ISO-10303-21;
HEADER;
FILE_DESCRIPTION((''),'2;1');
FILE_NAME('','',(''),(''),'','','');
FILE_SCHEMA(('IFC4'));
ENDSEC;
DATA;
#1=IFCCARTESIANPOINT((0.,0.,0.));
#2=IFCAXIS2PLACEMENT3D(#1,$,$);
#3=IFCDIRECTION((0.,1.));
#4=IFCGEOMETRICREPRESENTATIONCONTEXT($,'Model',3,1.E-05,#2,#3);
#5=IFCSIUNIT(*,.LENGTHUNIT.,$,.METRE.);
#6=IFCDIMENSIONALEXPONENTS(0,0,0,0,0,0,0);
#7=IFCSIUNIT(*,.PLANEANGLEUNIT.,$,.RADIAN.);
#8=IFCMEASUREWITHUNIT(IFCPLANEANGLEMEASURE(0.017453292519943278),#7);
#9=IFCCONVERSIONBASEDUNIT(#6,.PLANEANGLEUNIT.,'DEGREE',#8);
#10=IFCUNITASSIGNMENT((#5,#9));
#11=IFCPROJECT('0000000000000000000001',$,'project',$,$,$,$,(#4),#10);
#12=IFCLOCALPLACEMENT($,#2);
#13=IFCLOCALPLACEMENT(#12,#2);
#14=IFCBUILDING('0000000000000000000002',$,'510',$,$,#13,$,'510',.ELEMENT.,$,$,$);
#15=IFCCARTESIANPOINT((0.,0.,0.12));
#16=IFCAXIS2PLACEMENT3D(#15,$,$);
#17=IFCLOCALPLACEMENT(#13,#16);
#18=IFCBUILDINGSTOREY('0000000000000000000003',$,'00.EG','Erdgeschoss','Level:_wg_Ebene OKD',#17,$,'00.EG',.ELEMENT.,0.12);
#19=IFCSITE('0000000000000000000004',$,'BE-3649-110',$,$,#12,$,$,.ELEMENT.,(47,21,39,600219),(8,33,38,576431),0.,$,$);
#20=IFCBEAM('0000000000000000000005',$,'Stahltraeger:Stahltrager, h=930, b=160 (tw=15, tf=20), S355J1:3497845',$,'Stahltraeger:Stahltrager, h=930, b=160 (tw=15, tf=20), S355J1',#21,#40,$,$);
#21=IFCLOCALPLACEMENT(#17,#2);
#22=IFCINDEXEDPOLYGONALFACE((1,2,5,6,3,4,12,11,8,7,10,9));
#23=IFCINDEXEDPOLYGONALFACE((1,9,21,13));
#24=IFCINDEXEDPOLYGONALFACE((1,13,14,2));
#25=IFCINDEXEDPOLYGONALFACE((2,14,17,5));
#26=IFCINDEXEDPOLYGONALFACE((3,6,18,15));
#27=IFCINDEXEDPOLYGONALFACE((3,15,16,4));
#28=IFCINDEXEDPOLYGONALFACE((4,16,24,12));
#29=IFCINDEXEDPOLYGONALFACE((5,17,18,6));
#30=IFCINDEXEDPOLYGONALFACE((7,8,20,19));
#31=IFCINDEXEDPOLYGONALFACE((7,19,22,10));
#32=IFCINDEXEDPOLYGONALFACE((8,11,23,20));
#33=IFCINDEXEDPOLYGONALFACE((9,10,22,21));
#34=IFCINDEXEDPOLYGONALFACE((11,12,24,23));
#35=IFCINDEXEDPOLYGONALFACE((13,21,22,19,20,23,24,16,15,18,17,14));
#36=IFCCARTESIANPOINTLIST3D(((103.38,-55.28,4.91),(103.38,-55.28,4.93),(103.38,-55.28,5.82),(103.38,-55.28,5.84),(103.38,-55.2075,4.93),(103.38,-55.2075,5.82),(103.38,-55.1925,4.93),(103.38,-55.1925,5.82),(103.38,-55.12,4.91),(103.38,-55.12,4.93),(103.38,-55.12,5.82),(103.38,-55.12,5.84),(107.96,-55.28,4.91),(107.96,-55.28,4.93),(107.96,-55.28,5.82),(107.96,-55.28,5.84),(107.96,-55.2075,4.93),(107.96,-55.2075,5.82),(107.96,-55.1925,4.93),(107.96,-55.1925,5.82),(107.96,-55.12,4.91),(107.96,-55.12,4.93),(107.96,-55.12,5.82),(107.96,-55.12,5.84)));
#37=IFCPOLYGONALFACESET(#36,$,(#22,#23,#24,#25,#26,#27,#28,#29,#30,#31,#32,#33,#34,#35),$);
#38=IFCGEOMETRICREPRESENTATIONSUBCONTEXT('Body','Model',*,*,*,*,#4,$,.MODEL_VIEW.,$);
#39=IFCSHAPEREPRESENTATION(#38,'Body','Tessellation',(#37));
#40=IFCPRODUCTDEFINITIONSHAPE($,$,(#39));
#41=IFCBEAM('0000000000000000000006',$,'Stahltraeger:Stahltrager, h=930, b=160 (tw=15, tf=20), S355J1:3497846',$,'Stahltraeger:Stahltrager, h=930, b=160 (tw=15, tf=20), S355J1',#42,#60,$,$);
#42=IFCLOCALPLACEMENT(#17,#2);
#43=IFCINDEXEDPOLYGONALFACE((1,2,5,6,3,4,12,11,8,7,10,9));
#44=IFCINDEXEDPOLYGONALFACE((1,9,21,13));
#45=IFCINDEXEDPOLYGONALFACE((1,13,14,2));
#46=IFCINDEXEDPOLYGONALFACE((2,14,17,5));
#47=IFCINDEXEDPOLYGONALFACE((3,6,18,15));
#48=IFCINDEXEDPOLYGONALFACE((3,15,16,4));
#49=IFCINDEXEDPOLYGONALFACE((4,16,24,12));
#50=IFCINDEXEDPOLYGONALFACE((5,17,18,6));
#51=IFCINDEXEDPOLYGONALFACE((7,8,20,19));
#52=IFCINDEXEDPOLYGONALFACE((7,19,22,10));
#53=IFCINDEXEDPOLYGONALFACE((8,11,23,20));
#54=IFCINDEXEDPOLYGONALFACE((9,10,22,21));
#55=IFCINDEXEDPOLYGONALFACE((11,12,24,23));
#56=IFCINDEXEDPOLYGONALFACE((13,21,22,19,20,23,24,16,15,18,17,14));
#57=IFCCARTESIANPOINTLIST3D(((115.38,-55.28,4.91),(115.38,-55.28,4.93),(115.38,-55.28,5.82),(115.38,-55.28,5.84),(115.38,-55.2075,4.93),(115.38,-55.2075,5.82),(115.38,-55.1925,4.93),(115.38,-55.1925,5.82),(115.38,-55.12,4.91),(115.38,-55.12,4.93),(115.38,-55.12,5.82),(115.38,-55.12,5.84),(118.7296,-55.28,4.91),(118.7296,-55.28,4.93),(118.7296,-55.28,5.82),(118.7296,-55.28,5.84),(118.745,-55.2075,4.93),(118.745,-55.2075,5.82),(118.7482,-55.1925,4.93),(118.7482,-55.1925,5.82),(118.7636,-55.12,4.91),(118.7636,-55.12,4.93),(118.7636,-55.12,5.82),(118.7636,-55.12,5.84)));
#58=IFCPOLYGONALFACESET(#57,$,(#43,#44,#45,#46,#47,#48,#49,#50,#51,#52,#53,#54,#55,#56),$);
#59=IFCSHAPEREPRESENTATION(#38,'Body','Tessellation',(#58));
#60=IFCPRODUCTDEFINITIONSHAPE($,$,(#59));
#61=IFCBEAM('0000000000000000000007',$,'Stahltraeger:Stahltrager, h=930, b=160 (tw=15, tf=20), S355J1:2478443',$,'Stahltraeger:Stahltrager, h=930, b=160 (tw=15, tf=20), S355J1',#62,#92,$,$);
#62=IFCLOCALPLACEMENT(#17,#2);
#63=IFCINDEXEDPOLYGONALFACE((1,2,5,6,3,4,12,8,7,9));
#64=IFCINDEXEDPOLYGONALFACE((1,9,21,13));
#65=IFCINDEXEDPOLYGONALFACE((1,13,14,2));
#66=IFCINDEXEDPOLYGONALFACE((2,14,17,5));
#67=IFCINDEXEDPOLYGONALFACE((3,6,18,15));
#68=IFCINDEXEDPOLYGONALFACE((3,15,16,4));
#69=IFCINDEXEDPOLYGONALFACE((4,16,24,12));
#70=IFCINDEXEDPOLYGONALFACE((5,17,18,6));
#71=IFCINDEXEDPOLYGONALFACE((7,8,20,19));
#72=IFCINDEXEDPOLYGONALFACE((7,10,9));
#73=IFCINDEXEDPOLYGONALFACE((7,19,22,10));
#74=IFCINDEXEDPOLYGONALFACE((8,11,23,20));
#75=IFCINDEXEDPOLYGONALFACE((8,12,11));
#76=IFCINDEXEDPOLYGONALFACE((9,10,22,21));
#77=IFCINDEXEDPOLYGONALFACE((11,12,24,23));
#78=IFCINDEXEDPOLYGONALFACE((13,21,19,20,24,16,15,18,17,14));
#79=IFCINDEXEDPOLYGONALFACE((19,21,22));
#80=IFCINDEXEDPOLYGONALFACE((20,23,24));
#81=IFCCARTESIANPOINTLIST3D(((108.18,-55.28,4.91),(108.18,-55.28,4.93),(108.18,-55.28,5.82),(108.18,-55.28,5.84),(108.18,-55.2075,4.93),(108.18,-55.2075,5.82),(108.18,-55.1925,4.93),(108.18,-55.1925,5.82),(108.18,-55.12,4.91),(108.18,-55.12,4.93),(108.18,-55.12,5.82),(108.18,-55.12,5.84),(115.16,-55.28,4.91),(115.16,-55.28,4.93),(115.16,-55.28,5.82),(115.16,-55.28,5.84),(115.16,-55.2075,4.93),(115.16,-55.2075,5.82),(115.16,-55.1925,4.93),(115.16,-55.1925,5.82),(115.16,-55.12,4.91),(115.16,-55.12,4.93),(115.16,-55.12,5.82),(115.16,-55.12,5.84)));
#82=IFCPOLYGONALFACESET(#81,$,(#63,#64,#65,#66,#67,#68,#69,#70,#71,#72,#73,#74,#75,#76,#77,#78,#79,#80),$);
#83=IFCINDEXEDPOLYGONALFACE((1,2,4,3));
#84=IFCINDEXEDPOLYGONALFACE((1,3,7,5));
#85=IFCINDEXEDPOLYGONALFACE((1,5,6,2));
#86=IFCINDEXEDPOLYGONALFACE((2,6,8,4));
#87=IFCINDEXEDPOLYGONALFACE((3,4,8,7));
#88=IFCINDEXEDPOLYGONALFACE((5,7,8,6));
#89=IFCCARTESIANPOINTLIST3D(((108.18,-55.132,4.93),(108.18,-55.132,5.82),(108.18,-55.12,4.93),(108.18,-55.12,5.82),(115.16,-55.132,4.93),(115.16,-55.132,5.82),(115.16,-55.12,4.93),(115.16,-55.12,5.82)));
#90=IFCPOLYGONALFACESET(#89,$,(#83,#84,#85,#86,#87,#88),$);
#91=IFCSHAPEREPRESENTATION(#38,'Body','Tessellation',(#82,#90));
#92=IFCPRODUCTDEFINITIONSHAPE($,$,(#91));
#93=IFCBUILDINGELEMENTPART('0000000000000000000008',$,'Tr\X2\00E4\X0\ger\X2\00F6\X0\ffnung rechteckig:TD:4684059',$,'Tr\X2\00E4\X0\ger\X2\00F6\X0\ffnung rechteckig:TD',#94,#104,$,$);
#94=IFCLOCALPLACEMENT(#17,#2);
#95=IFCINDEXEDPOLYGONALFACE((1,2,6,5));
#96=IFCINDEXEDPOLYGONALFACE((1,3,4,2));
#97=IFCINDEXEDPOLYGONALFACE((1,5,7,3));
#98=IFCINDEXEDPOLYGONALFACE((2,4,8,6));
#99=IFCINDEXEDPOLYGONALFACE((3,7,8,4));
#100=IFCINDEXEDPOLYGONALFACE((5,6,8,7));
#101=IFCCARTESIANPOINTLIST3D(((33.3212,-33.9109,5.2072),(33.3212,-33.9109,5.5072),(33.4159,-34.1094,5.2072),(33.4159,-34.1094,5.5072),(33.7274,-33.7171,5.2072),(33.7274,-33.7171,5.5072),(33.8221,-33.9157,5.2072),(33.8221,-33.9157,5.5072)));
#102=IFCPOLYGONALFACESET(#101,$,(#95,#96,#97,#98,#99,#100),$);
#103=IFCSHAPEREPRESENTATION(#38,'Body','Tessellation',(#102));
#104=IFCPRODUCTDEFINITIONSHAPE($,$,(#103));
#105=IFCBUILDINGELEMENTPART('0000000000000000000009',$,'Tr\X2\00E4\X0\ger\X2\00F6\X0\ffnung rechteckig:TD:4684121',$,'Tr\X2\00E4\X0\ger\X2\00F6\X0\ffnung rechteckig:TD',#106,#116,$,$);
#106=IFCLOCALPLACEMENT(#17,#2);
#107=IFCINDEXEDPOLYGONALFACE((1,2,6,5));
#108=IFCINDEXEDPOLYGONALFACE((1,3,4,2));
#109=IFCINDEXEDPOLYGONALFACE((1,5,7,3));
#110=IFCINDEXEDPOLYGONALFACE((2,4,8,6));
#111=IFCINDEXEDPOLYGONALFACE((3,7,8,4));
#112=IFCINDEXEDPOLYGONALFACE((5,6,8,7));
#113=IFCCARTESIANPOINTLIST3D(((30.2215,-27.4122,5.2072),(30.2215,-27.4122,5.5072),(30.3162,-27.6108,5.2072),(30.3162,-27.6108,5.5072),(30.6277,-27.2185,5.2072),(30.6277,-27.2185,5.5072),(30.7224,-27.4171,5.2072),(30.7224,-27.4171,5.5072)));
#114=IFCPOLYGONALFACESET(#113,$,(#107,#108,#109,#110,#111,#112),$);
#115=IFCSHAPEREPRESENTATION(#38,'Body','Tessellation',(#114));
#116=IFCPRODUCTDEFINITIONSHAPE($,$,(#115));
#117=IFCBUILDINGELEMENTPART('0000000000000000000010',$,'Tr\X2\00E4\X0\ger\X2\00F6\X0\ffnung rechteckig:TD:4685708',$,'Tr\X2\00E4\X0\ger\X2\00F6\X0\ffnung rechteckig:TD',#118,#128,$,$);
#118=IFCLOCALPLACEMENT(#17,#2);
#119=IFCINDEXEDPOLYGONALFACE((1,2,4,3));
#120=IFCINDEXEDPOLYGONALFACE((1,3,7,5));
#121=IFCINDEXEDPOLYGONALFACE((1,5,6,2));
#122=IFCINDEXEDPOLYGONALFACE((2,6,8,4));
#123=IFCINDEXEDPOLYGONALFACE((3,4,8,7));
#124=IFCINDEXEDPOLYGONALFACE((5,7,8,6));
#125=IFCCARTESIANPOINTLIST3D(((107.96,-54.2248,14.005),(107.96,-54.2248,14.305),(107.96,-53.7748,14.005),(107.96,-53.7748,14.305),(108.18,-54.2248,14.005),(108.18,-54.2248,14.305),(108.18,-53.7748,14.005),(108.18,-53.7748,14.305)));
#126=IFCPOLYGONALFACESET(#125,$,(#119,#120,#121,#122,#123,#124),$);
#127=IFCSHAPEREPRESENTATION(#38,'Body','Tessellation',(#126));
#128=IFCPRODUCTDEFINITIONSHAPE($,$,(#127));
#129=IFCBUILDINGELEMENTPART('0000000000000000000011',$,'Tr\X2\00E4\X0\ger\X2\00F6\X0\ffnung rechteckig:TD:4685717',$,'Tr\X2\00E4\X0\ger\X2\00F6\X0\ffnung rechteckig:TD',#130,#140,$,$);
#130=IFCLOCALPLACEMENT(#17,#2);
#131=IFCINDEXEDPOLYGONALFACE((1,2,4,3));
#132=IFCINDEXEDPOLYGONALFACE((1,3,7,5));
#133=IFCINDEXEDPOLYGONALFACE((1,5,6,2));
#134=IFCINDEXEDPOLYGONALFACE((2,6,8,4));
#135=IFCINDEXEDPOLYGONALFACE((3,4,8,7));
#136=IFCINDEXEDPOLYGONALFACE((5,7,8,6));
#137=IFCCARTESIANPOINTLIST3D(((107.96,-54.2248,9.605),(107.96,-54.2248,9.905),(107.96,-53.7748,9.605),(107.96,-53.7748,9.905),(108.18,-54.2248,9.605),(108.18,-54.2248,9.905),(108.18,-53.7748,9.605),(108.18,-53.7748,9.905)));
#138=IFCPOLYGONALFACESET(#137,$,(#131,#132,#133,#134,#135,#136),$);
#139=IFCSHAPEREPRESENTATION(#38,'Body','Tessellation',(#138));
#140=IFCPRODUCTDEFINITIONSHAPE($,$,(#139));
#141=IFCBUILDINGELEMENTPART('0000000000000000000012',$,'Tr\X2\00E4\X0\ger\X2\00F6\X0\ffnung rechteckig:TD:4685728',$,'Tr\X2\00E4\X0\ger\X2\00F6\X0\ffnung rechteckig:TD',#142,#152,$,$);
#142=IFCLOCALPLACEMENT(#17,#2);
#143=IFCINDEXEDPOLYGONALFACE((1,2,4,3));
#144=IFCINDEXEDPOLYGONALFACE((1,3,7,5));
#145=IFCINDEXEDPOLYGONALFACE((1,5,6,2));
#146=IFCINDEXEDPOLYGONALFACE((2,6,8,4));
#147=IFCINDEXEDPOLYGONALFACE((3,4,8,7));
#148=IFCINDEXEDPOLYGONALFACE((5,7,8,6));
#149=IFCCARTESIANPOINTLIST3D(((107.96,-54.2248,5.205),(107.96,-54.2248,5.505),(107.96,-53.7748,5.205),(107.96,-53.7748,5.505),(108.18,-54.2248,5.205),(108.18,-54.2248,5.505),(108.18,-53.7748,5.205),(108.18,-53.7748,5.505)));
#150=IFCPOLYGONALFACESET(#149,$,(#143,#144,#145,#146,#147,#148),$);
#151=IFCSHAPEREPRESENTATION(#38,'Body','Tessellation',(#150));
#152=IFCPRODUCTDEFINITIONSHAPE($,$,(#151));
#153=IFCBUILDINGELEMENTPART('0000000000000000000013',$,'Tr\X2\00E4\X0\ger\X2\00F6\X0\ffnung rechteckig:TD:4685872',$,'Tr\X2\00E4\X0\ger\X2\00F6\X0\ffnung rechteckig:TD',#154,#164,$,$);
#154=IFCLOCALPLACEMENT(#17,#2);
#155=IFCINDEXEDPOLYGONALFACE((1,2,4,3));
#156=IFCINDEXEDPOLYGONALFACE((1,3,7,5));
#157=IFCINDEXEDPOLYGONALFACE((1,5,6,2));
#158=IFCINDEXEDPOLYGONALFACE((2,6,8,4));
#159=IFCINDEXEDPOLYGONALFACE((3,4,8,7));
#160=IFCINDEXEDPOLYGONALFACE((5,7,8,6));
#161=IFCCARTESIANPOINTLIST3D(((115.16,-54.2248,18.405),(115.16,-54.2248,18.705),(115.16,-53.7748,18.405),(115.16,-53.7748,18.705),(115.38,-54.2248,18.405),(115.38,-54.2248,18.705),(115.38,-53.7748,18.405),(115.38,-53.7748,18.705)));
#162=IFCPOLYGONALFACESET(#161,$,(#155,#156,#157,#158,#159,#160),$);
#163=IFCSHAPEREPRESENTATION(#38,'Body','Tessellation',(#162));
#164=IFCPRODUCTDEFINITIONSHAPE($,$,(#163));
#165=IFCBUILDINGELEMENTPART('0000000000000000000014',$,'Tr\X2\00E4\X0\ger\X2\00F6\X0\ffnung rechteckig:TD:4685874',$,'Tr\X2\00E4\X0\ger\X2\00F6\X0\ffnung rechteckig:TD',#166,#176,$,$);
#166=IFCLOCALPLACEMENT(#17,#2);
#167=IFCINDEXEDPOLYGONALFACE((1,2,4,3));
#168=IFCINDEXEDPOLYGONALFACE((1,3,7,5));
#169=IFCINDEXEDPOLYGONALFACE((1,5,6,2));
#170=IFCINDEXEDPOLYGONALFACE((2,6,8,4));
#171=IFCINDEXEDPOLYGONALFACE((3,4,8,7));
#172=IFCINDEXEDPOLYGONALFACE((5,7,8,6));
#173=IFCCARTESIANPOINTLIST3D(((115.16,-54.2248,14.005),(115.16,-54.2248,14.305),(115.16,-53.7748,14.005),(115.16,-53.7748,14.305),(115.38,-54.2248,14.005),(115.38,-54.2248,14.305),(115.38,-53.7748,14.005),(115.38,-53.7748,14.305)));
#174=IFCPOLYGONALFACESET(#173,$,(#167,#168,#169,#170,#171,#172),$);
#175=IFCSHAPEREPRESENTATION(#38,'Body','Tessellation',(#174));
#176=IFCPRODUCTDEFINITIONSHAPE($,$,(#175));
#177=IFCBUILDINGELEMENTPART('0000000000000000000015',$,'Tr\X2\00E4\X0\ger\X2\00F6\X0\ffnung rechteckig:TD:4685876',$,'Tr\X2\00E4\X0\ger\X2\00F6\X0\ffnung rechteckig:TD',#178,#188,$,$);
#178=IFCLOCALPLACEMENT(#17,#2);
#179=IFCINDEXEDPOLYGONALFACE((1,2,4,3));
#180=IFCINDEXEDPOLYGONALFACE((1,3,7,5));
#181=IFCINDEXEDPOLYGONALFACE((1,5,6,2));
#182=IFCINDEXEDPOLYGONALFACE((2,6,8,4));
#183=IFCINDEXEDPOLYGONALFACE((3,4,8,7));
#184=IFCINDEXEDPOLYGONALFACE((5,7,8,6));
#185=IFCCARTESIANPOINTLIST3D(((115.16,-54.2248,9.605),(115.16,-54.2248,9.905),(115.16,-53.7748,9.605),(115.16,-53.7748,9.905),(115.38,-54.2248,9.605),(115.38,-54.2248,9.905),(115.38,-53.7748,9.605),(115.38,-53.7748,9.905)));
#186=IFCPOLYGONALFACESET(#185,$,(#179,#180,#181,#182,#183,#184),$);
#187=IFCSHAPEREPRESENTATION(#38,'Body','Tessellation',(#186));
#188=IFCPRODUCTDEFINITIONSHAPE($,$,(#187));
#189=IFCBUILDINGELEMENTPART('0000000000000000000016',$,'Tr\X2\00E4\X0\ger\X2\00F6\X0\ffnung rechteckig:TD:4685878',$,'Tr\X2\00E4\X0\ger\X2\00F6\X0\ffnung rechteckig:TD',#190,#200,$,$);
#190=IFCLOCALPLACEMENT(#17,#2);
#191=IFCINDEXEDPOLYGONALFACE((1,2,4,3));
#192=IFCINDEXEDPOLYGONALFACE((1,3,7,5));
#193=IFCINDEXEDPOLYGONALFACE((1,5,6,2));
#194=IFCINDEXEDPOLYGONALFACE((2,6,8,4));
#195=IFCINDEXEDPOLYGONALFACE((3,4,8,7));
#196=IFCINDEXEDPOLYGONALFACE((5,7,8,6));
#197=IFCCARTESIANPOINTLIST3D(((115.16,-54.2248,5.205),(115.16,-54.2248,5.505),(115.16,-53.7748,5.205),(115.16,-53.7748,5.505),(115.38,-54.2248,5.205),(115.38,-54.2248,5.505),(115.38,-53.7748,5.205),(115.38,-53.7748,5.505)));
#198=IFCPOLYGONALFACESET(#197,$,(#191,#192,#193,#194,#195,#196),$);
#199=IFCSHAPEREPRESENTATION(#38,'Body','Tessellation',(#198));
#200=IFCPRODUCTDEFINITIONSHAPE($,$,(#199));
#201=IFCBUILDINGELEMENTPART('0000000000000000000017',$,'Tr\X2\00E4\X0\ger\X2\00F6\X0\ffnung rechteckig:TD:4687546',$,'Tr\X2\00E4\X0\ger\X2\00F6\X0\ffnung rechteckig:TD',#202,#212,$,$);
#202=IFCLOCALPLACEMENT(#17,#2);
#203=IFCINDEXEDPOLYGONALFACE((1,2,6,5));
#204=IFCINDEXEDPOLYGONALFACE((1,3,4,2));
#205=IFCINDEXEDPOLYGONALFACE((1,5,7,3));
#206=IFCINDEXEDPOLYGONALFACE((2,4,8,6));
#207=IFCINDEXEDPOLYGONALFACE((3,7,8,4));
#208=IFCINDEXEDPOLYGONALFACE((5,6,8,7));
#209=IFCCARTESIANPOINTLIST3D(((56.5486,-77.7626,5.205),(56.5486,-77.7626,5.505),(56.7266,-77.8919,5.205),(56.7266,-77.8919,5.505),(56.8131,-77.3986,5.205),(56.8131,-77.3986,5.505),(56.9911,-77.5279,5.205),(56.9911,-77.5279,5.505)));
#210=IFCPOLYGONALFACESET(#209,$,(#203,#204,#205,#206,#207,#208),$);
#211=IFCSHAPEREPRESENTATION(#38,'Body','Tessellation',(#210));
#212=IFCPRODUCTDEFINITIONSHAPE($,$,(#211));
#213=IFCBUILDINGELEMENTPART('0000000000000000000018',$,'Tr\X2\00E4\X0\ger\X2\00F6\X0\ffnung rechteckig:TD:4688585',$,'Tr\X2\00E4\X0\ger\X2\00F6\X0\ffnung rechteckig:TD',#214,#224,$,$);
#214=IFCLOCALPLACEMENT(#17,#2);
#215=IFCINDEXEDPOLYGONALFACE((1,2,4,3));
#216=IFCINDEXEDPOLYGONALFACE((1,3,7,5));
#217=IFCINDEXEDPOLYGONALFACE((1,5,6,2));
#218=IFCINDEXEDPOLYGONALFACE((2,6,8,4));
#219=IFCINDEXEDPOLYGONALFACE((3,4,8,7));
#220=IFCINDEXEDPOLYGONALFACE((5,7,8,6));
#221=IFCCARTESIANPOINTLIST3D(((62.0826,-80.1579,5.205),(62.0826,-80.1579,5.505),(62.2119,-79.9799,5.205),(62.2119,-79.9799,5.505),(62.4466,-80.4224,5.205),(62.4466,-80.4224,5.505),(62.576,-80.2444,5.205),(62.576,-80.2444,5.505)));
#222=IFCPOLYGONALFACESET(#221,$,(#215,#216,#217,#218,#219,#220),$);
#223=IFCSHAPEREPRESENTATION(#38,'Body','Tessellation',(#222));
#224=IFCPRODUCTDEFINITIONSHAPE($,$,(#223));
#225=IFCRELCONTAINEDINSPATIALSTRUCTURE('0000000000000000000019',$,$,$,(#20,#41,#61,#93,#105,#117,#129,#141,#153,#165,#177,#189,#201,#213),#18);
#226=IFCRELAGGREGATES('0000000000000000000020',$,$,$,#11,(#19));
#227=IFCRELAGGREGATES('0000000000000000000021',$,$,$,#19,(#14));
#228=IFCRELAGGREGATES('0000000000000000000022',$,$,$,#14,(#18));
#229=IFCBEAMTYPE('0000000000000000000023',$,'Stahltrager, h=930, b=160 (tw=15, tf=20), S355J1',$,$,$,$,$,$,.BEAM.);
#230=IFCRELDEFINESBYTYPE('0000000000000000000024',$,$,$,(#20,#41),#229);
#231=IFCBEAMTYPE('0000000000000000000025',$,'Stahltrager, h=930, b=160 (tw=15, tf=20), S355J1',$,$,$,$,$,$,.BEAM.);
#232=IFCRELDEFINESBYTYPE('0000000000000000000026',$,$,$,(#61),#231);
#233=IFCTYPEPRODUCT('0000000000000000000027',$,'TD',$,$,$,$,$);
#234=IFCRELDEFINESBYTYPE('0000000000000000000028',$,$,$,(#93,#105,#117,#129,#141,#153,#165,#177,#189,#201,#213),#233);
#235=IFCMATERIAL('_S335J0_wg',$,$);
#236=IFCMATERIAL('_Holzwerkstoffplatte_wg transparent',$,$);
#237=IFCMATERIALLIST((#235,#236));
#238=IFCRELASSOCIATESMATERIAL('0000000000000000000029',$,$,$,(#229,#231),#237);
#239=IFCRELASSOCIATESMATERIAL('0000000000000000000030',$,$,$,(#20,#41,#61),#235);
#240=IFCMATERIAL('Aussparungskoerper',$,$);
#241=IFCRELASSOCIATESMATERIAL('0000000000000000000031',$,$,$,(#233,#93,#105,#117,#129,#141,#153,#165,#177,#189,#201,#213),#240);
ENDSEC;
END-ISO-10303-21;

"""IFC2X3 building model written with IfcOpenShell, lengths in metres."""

from ifc_helpers import new_model, entity, si_unit, converted_unit, direction, frame, frame_2d, origin, origin_2d_with_axis, place, context, subcontext, project, spatial, polyline, rectangle, i_section, outline, extrude, clip, halfspace, source, transform, mapped, material, material_list, type_object, type_shapes, element, save


model = new_model("IFC2X3")

# Units and contexts
model_context = context("Model", 3, precision=1e-05, world=origin(), true_north=direction((0.0, 1.0)))
body_context = subcontext(model_context, "Body", "Model", "MODEL_VIEW")
ifc_project = project(units=[si_unit("LENGTHUNIT", "METRE"), converted_unit("PLANEANGLEUNIT", "DEGREE", entity("IfcPlaneAngleMeasure", 0.017453292519943278), si_unit("PLANEANGLEUNIT", "RADIAN"), dimensions=[0, 0, 0, 0, 0, 0, 0])], contexts=[model_context])

# Site, building, storey
site_placement = place(None, origin())
site = spatial("IfcSite", under=ifc_project, at=site_placement, Name="BE-3649-110", CompositionType="ELEMENT", RefLatitude=(47, 21, 39, 600219), RefLongitude=(8, 33, 38, 576431), RefElevation=0.0)
building_placement = place(site_placement, origin())
building = spatial("IfcBuilding", under=site, at=building_placement, Name="510", LongName="510", CompositionType="ELEMENT")
storey_placement = place(building_placement, frame((0.0, 0.0, 0.12)))
storey = spatial("IfcBuildingStorey", under=building, at=storey_placement, Name="00.EG", Description="Erdgeschoss", ObjectType="Level:_wg_Ebene OKD", LongName="00.EG", CompositionType="ELEMENT", Elevation=0.12)

# Beams
ifc_material_1 = material(Name="_S335J0_wg")
ifc_material_2 = material(Name="_Holzwerkstoffplatte_wg transparent")
ifc_material_list = material_list([ifc_material_1, ifc_material_2])
beam_type_1 = type_object("IfcBeamType", Name="Stahltrager, h=930, b=160 (tw=15, tf=20), S355J1", PredefinedType="BEAM", material=ifc_material_list)
beam_1_placement = place(storey_placement, frame((103.38, -55.28, 4.91)))
element("IfcBeam", 1, at=beam_1_placement, inside=storey, type_object=beam_type_1, material=ifc_material_1, Name="Stahltraeger:Stahltrager, h=930, b=160 (tw=15, tf=20), S355J1:3497845", ObjectType="Stahltraeger:Stahltrager, h=930, b=160 (tw=15, tf=20), S355J1", context=body_context, shape_type="SweptSolid", body=[
    extrude(outline(polyline([(-0.08, -0.445), (-0.08, -0.465), (0.08, -0.465), (0.08, -0.445), (0.0075, -0.445), (0.0075, 0.445), (0.08, 0.445), (0.08, 0.465), (-0.08, 0.465), (-0.08, 0.445), (-0.0075, 0.445), (-0.0075, -0.445), (-0.08, -0.445)])), frame((0.0, 0.08, 0.465), z_axis=(-1.0, 0.0, 0.0), x_axis=(0.0, -1.0, 0.0)), (0.0, 0.0, -1.0), 4.58),
])
beam_2_placement = place(storey_placement, frame((115.38, -55.2, 5.84)))
element("IfcBeam", 2, at=beam_2_placement, inside=storey, type_object=beam_type_1, material=ifc_material_1, Name="Stahltraeger:Stahltrager, h=930, b=160 (tw=15, tf=20), S355J1:3497846", ObjectType="Stahltraeger:Stahltrager, h=930, b=160 (tw=15, tf=20), S355J1", context=body_context, shape_type="SweptSolid", body=[
    clip(extrude(i_section(OverallWidth=0.16, OverallDepth=0.93, WebThickness=0.015, FlangeThickness=0.02, at=frame_2d((0.0, 0.0), x_axis=(0.0, 1.0))), frame((0.0, 0.0, -0.465), z_axis=(1.0, 0.0, 0.0), x_axis=(0.0, 0.0, -1.0)), (0.0, 0.0, 1.0), 3.3836), halfspace(frame((3.2599, -0.5018, 18.82), z_axis=(0.978148, -0.207912, 0.0), x_axis=(0.207912, 0.978148, 0.0)), False)),
])
beam_type_2 = type_object("IfcBeamType", Name="Stahltrager, h=930, b=160 (tw=15, tf=20), S355J1", PredefinedType="BEAM", material=ifc_material_list)
shared_shape_1 = source(origin(), body_context, "Body", "SweptSolid", [
    extrude(i_section(OverallWidth=0.16, OverallDepth=0.93, WebThickness=0.015, FlangeThickness=0.02, at=frame_2d((0.0, 0.0), x_axis=(0.0, 1.0))), frame((-3.49, 0.0, 0.0), z_axis=(1.0, 0.0, 0.0), x_axis=(0.0, 0.0, -1.0)), (0.0, 0.0, 1.0), 6.98),
    extrude(rectangle(XDim=0.89, YDim=0.012, at=origin_2d_with_axis()), frame((-3.49, 0.074, 0.0), z_axis=(1.0, 0.0, 0.0), x_axis=(0.0, 0.0, -1.0)), (0.0, 0.0, 1.0), 6.98),
])
type_shapes(beam_type_2, [shared_shape_1])
beam_3_placement = place(storey_placement, frame((111.67, -55.2, 5.375)))
element("IfcBeam", 3, at=beam_3_placement, inside=storey, type_object=beam_type_2, material=ifc_material_1, Name="Stahltraeger:Stahltrager, h=930, b=160 (tw=15, tf=20), S355J1:2478443", ObjectType="Stahltraeger:Stahltrager, h=930, b=160 (tw=15, tf=20), S355J1", context=body_context, shape_type="MappedRepresentation", body=[
    mapped(shared_shape_1, transform((0.0, 0.0, 0.0), scale=1.0)),
])

# Building element parts
ifc_material_3 = material(Name="Aussparungskoerper")
type_product_1 = type_object("IfcTypeProduct", Name="TD", material=ifc_material_3)
shared_shape_2 = source(origin(), body_context, "Body", "SweptSolid", [
    extrude(rectangle(XDim=0.45, YDim=0.3, at=origin_2d_with_axis()), frame((0.0, 0.0, -0.22), z_axis=(0.0, 0.0, 1.0), x_axis=(-1.0, 0.0, 0.0)), (0.0, 0.0, 1.0), 0.22),
])
type_shapes(type_product_1, [shared_shape_2])
for number, where, z_axis, x_axis, name in (
    (4, (33.619, -34.0126, 5.3572), (0.430511, -0.902585, 0.0), (-0.902585, -0.430511, 0.0), "Trägeröffnung rechteckig:TD:4684059"),
    (5, (30.5193, -27.5139, 5.3572), (0.430511, -0.902585, 0.0), (-0.902585, -0.430511, 0.0), "Trägeröffnung rechteckig:TD:4684121"),
    (6, (107.96, -53.9998, 14.155), (-1.0, 0.0, 0.0), (0.0, -1.0, 0.0), "Trägeröffnung rechteckig:TD:4685708"),
    (7, (107.96, -53.9998, 9.755), (-1.0, 0.0, 0.0), (0.0, -1.0, 0.0), "Trägeröffnung rechteckig:TD:4685717"),
    (8, (107.96, -53.9998, 5.355), (-1.0, 0.0, 0.0), (0.0, -1.0, 0.0), "Trägeröffnung rechteckig:TD:4685728"),
    (9, (115.16, -53.9998, 18.555), (-1.0, 0.0, 0.0), (0.0, -1.0, 0.0), "Trägeröffnung rechteckig:TD:4685872"),
    (10, (115.16, -53.9998, 14.155), (-1.0, 0.0, 0.0), (0.0, -1.0, 0.0), "Trägeröffnung rechteckig:TD:4685874"),
    (11, (115.16, -53.9998, 9.755), (-1.0, 0.0, 0.0), (0.0, -1.0, 0.0), "Trägeröffnung rechteckig:TD:4685876"),
    (12, (115.16, -53.9998, 5.355), (-1.0, 0.0, 0.0), (0.0, -1.0, 0.0), "Trägeröffnung rechteckig:TD:4685878"),
    (13, (56.8588, -77.7099, 5.355), (0.809017, -0.587785, 0.0), (-0.587785, -0.809017, 0.0), "Trägeröffnung rechteckig:TD:4687546"),
    (14, (62.2646, -80.2901, 5.355), (-0.587785, -0.809017, 0.0), (0.809017, -0.587785, 0.0), "Trägeröffnung rechteckig:TD:4688585"),
):
    element("IfcBuildingElementPart", number, at=place(storey_placement, frame(where, z_axis=z_axis, x_axis=x_axis)), inside=storey, type_object=type_product_1, material=ifc_material_3, Name=name, ObjectType="Trägeröffnung rechteckig:TD", context=body_context, shape_type="MappedRepresentation", body=[
        mapped(shared_shape_2, transform((0.0, 0.0, 0.0), scale=1.0)),
    ])

save(model, "model.ifc")
